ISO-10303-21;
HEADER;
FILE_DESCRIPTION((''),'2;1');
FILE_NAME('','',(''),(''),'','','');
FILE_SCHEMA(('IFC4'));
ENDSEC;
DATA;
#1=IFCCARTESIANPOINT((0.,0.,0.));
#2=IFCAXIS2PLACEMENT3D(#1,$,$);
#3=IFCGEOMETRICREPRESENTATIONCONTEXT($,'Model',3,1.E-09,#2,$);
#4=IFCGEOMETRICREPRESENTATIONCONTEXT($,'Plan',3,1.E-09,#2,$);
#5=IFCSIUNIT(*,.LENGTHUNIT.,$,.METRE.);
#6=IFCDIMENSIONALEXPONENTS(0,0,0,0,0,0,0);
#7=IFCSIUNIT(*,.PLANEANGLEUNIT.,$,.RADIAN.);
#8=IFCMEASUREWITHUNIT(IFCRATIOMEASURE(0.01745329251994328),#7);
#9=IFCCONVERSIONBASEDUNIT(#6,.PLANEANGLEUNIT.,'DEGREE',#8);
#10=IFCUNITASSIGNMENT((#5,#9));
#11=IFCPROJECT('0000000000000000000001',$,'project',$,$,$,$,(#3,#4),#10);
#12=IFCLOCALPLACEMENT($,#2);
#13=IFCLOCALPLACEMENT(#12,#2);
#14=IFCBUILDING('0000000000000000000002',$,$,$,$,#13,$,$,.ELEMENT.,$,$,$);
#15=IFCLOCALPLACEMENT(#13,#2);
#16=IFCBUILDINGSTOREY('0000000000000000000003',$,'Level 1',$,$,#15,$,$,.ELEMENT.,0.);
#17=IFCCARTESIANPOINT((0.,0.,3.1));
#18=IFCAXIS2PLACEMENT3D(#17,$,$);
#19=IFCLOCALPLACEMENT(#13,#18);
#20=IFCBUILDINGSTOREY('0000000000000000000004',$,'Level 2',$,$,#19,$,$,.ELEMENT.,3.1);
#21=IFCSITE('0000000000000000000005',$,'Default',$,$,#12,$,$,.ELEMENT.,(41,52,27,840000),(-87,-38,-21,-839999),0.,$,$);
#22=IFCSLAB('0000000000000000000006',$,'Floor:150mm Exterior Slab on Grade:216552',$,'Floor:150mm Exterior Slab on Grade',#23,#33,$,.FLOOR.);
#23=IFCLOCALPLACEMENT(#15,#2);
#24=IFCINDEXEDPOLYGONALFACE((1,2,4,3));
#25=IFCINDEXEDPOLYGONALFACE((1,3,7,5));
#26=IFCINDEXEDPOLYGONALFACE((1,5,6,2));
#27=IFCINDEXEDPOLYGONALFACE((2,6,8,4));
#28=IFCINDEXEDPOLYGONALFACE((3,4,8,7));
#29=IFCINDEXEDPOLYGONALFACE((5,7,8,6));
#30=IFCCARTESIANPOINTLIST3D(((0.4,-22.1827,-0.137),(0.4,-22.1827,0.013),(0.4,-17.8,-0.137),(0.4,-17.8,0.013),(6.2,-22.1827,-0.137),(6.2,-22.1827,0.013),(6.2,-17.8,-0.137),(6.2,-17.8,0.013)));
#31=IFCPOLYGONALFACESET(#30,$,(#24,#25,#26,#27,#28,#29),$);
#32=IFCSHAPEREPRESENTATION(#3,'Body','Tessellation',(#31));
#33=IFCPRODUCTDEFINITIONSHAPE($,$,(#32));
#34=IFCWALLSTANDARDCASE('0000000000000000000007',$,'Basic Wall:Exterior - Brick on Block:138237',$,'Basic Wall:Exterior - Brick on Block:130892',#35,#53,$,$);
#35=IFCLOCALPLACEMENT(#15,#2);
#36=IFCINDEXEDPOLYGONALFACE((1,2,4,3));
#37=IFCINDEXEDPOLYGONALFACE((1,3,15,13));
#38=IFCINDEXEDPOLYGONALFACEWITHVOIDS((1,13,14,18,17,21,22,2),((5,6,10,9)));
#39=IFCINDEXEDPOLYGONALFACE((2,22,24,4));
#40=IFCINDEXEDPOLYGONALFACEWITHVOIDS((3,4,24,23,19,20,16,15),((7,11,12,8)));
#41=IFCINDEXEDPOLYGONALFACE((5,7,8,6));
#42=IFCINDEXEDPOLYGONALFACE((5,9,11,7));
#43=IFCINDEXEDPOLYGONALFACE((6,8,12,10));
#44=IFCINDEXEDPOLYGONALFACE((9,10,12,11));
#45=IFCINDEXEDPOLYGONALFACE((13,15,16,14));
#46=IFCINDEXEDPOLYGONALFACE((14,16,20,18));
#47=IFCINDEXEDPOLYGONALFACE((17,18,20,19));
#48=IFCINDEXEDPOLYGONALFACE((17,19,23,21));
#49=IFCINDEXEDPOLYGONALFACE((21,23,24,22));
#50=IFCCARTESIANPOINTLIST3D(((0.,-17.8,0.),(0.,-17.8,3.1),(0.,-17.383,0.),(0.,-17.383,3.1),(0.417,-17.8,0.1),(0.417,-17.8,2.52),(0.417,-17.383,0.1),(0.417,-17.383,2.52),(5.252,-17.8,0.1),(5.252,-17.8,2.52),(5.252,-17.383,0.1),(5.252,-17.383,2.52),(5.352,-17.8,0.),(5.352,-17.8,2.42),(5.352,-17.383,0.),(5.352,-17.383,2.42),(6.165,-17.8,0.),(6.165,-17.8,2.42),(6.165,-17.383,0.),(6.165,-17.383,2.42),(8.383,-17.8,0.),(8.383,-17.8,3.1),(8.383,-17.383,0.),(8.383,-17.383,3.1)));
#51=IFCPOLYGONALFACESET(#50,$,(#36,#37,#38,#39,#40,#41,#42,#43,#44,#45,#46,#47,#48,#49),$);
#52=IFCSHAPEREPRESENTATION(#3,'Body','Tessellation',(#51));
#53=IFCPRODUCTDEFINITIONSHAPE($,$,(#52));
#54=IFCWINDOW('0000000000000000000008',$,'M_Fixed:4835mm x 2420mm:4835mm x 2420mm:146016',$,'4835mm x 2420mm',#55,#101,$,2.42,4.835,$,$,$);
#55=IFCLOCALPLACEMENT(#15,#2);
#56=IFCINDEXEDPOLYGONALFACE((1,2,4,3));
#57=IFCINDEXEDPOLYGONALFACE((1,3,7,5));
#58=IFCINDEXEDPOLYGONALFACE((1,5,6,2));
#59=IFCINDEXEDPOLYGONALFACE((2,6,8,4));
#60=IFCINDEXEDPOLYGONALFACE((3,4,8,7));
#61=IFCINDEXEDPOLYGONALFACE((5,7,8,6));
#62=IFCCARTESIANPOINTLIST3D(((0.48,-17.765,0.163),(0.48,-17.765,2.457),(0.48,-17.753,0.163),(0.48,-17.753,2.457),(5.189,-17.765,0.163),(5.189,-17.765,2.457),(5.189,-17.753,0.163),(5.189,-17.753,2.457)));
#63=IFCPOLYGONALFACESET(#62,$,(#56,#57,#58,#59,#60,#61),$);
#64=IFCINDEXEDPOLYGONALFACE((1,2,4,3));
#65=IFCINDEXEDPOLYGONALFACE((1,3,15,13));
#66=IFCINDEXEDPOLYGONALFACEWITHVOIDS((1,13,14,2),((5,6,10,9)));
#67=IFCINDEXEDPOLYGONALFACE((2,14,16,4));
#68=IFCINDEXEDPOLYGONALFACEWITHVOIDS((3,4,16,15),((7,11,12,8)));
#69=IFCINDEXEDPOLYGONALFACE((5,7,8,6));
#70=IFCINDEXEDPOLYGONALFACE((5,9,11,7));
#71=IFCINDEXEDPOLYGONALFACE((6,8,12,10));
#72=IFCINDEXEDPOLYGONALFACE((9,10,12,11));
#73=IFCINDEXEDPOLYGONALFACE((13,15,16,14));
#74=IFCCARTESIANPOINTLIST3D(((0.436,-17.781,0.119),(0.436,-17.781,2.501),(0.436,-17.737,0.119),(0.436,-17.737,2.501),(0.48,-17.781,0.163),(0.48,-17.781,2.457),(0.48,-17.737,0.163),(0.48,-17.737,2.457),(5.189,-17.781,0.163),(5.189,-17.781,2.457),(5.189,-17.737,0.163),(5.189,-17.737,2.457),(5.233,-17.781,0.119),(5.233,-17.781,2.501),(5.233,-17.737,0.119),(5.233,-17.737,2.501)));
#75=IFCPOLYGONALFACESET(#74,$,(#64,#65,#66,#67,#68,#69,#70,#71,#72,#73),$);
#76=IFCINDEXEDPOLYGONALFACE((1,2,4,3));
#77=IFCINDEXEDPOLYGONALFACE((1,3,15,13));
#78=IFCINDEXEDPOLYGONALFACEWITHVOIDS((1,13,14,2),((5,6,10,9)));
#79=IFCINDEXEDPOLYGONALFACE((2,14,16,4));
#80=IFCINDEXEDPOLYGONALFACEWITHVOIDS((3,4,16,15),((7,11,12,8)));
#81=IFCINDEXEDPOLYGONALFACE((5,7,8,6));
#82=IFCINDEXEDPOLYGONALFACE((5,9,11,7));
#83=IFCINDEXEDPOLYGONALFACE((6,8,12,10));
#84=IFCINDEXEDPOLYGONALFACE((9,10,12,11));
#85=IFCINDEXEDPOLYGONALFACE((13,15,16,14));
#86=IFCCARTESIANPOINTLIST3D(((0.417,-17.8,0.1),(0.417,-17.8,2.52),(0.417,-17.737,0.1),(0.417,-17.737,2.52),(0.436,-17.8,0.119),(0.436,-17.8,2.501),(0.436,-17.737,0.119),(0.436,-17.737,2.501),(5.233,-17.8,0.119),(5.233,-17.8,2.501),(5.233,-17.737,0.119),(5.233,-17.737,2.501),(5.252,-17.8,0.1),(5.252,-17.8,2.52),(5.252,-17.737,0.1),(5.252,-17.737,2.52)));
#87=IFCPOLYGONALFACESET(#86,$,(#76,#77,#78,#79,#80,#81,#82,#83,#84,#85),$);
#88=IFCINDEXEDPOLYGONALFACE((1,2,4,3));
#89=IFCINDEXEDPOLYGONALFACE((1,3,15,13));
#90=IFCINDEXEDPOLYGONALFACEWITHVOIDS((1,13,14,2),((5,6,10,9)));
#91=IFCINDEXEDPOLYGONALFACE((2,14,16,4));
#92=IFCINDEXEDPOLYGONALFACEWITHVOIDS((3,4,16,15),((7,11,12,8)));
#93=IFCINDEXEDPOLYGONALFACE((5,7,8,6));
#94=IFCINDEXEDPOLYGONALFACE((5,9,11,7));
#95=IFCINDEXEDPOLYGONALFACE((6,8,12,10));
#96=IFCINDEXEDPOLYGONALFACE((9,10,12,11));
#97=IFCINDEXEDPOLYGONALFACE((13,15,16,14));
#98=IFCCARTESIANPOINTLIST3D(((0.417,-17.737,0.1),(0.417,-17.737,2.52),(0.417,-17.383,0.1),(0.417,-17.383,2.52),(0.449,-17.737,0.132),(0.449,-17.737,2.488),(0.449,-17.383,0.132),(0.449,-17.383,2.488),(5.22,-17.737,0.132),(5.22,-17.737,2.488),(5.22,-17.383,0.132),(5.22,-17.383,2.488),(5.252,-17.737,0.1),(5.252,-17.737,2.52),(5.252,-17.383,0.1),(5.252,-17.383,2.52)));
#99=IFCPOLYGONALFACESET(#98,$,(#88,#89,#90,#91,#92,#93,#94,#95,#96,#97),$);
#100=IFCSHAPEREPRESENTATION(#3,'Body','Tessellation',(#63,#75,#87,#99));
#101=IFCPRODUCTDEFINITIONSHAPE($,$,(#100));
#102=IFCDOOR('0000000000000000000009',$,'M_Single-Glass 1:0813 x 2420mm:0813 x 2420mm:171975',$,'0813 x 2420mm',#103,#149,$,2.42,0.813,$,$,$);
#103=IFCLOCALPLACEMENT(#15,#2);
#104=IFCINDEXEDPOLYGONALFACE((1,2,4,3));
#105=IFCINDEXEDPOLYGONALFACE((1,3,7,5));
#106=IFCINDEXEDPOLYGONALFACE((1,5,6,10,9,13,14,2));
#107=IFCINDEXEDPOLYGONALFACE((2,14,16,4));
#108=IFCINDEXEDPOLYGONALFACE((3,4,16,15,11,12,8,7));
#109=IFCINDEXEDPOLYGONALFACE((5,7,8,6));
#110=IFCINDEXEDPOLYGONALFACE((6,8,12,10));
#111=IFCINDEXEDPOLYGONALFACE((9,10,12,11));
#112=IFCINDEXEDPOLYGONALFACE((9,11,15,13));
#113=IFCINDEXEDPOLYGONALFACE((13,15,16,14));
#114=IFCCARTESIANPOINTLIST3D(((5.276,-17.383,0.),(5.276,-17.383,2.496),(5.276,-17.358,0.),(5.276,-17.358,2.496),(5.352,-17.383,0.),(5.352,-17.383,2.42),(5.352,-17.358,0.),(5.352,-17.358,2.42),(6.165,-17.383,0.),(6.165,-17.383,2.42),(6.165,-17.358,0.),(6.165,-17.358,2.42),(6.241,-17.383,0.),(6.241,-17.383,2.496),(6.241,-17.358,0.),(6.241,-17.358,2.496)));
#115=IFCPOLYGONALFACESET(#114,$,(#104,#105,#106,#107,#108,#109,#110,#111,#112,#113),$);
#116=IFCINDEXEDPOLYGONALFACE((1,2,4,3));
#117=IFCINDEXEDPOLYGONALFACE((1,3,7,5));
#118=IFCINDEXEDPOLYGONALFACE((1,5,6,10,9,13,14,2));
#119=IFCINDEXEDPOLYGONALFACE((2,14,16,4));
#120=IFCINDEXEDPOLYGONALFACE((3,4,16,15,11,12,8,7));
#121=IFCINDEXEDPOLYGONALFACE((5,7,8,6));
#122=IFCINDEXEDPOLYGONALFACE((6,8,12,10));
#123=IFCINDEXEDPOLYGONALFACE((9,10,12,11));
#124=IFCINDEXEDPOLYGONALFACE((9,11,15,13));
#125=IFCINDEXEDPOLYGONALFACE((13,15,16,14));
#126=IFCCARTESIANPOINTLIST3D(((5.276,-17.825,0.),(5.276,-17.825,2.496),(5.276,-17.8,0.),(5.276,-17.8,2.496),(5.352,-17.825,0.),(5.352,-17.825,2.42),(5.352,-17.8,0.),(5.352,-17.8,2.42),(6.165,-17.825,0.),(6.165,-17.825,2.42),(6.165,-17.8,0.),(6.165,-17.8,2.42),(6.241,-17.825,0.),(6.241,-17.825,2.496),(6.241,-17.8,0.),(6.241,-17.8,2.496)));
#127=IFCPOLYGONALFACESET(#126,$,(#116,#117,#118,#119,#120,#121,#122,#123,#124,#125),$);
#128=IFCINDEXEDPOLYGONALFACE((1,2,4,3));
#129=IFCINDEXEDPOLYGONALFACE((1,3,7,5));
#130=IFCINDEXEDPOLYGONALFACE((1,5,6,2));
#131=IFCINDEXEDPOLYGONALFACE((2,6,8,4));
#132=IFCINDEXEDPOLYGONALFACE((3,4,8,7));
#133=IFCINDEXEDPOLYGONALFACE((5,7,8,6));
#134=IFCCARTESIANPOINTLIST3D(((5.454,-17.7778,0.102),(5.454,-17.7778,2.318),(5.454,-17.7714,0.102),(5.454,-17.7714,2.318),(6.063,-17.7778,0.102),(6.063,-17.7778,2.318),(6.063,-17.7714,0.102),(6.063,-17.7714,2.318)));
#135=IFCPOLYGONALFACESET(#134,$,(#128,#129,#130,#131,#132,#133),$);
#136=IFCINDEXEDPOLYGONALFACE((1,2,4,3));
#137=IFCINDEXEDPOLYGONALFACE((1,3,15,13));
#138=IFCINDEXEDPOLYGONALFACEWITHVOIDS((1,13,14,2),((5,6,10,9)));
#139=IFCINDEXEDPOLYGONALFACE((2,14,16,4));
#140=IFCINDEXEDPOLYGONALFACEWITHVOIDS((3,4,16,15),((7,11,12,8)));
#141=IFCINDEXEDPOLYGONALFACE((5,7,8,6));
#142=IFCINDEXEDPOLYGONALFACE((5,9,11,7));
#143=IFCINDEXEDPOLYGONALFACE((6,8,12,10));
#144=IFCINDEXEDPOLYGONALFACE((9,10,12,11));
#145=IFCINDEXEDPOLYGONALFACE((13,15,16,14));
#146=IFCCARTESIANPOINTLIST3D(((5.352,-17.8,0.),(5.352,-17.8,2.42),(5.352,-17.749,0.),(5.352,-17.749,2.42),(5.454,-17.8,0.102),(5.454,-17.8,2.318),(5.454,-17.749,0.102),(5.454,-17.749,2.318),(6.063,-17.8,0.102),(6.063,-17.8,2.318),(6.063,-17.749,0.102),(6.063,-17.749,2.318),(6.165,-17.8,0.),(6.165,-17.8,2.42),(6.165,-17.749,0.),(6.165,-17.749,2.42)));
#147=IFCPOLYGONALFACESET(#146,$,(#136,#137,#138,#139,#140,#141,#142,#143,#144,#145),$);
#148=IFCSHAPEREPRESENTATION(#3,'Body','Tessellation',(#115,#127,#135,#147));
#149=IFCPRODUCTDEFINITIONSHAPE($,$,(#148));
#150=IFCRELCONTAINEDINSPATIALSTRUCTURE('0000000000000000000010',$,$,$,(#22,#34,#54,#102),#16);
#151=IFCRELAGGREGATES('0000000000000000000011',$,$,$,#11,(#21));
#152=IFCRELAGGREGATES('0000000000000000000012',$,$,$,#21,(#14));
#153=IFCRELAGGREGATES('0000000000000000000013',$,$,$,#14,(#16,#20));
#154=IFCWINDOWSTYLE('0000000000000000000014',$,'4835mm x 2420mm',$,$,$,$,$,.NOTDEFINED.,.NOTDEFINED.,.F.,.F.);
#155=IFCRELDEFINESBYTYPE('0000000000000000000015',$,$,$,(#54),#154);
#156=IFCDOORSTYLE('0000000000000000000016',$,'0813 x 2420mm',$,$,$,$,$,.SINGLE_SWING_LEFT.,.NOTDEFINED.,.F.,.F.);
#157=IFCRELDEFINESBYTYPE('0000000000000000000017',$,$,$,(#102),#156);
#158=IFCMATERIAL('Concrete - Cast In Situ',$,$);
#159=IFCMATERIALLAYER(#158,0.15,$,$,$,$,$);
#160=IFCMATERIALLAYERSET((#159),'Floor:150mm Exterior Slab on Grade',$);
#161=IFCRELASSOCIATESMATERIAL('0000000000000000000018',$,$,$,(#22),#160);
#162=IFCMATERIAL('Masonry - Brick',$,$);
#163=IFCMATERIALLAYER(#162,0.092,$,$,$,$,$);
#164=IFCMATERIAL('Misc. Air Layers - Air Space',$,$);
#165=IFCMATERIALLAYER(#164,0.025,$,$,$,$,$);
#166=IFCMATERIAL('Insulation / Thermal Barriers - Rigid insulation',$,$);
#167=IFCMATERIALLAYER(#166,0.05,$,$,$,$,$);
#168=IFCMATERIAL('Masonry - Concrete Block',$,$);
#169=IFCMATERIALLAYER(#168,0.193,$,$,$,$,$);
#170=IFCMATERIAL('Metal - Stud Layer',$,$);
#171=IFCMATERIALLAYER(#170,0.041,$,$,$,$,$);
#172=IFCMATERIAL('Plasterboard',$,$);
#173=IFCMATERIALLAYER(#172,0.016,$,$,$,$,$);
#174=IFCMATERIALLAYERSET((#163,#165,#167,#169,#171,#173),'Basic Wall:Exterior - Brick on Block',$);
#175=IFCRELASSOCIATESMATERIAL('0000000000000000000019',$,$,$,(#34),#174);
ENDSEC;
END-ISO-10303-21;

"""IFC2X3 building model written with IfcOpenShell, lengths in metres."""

from ifc_helpers import new_model, entity, si_unit, converted_unit, frame, frame_2d, origin, origin_2d_with_axis, place, context, project, spatial, polyline, rectangle, outline, extrude, source, transform, mapped, material, layer, layer_set, layer_usage, type_object, type_shapes, element, fill, save


model = new_model("IFC2X3")

# Units and contexts
model_context = context("Model", 3, precision=1e-09, world=origin())
plan_context = context("Plan", 3, precision=1e-09, world=origin())
ifc_project = project(units=[si_unit("LENGTHUNIT", "METRE"), converted_unit("PLANEANGLEUNIT", "DEGREE", entity("IfcRatioMeasure", 0.01745329251994328), si_unit("PLANEANGLEUNIT", "RADIAN"), dimensions=[0, 0, 0, 0, 0, 0, 0])], contexts=[model_context, plan_context])

# Site, building, storey
site_placement = place(None, origin())
site = spatial("IfcSite", under=ifc_project, at=site_placement, Name="Default", CompositionType="ELEMENT", RefLatitude=(41, 52, 27, 840000), RefLongitude=(-87, -38, -21, -839999), RefElevation=0.0)
building_placement = place(site_placement, origin())
building = spatial("IfcBuilding", under=site, at=building_placement, CompositionType="ELEMENT")
storey_1_placement = place(building_placement, origin())
storey_1 = spatial("IfcBuildingStorey", under=building, at=storey_1_placement, Name="Level 1", CompositionType="ELEMENT", Elevation=0.0)

# Slab
ifc_material_1 = material(Name="Concrete - Cast In Situ")
ifc_layer_1 = layer(ifc_material_1, 0.15)
ifc_layer_set_1 = layer_set([ifc_layer_1], Name="Floor:150mm Exterior Slab on Grade")
ifc_layer_usage_1 = layer_usage(ifc_layer_set_1, "AXIS3", "POSITIVE", 0.0)
slab_1_placement = place(storey_1_placement, frame((0.4, -22.1827, -0.137)))
element("IfcSlab", 1, at=slab_1_placement, inside=storey_1, material=ifc_layer_usage_1, Name="Floor:150mm Exterior Slab on Grade:216552", ObjectType="Floor:150mm Exterior Slab on Grade", PredefinedType="FLOOR", context=model_context, shape_type="SweptSolid", body=[
    extrude(rectangle(XDim=5.8, YDim=4.3827, at=origin_2d_with_axis()), frame((2.9, 2.1914, 0.15), z_axis=(0.0, 0.0, -1.0), x_axis=(-1.0, 0.0, 0.0)), (0.0, 0.0, 1.0), 0.15),
])

# Wall, openings, window, door
ifc_material_2 = material(Name="Masonry - Brick")
ifc_layer_2 = layer(ifc_material_2, 0.092)
ifc_material_3 = material(Name="Misc. Air Layers - Air Space")
ifc_layer_3 = layer(ifc_material_3, 0.025)
ifc_material_4 = material(Name="Insulation / Thermal Barriers - Rigid insulation")
ifc_layer_4 = layer(ifc_material_4, 0.05)
ifc_material_5 = material(Name="Masonry - Concrete Block")
ifc_layer_5 = layer(ifc_material_5, 0.193)
ifc_material_6 = material(Name="Metal - Stud Layer")
ifc_layer_6 = layer(ifc_material_6, 0.041)
ifc_material_7 = material(Name="Plasterboard")
ifc_layer_7 = layer(ifc_material_7, 0.016)
ifc_layer_set_2 = layer_set([ifc_layer_2, ifc_layer_3, ifc_layer_4, ifc_layer_5, ifc_layer_6, ifc_layer_7], Name="Basic Wall:Exterior - Brick on Block")
ifc_layer_usage_2 = layer_usage(ifc_layer_set_2, "AXIS2", "NEGATIVE", 0.2085)
wall_1_placement = place(storey_1_placement, frame((8.383, -17.5915, 0.0), z_axis=(0.0, 0.0, 1.0), x_axis=(-1.0, 0.0, 0.0)))
wall_1 = element("IfcWallStandardCase", 2, at=wall_1_placement, inside=storey_1, material=ifc_layer_usage_2, Name="Basic Wall:Exterior - Brick on Block:138237", ObjectType="Basic Wall:Exterior - Brick on Block:130892", context=model_context, shape_type="SweptSolid", body=[
    extrude(rectangle(XDim=8.383, YDim=0.417, at=frame_2d((4.1915, 0.0), x_axis=(-1.0, 0.0))), origin(), (0.0, 0.0, 1.0), 3.1),
])
opening_1_placement = place(wall_1_placement, frame((3.131, -0.2085, 0.1)))
opening_1 = element("IfcOpeningElement", 3, at=opening_1_placement, cuts=wall_1, ObjectType="Opening", context=model_context, shape_type="SweptSolid", body=[
    extrude(rectangle(XDim=2.42, YDim=4.835, at=frame_2d((1.21, 2.4175), x_axis=(1.0, 0.0))), frame((0.0, 0.0, 0.0), z_axis=(0.0, 1.0, 0.0), x_axis=(0.0, 0.0, 1.0)), (0.0, 0.0, 1.0), 0.417),
])
opening_2_placement = place(wall_1_placement, frame((2.218, -0.2085, 0.0)))
opening_2 = element("IfcOpeningElement", 4, at=opening_2_placement, cuts=wall_1, ObjectType="Opening", context=model_context, shape_type="SweptSolid", body=[
    extrude(rectangle(XDim=0.813, YDim=2.42, at=frame_2d((1.21, 0.4065), x_axis=(0.0, -1.0))), frame((0.0, 0.0, 0.0), z_axis=(0.0, 1.0, 0.0), x_axis=(0.0, 0.0, 1.0)), (0.0, 0.0, 1.0), 0.417),
])
window_style_1 = type_object("IfcWindowStyle", Name="4835mm x 2420mm", ConstructionType="NOTDEFINED", OperationType="NOTDEFINED", ParameterTakesPrecedence=False, Sizeable=False)
shared_shape_1 = source(origin(), model_context, "Body", "SweptSolid", [
    extrude(rectangle(XDim=0.012, YDim=4.709, at=origin_2d_with_axis()), frame((2.4175, 0.376, 0.063), z_axis=(0.0, 0.0, 1.0), x_axis=(0.0, -1.0, 0.0)), (0.0, 0.0, 1.0), 2.294),
    extrude(outline(polyline([(-2.3985, -1.191), (2.3985, -1.191), (2.3985, 1.191), (-2.3985, 1.191), (-2.3985, -1.191)]), holes=[polyline([(-2.3545, -1.147), (-2.3545, 1.147), (2.3545, 1.147), (2.3545, -1.147), (-2.3545, -1.147)])]), frame((2.4175, 0.354, 1.21), z_axis=(0.0, 1.0, 0.0), x_axis=(1.0, 0.0, 0.0)), (0.0, 0.0, 1.0), 0.044),
    extrude(outline(polyline([(-2.4175, -1.21), (2.4175, -1.21), (2.4175, 1.21), (-2.4175, 1.21), (-2.4175, -1.21)]), holes=[polyline([(-2.3985, -1.191), (-2.3985, 1.191), (2.3985, 1.191), (2.3985, -1.191), (-2.3985, -1.191)])]), frame((2.4175, 0.354, 1.21), z_axis=(0.0, 1.0, 0.0), x_axis=(1.0, 0.0, 0.0)), (0.0, 0.0, 1.0), 0.063),
    extrude(outline(polyline([(-2.4175, -1.21), (2.4175, -1.21), (2.4175, 1.21), (-2.4175, 1.21), (-2.4175, -1.21)]), holes=[polyline([(-2.3855, -1.178), (-2.3855, 1.178), (2.3855, 1.178), (2.3855, -1.178), (-2.3855, -1.178)])]), frame((2.4175, 0.0, 1.21), z_axis=(0.0, 1.0, 0.0), x_axis=(1.0, 0.0, 0.0)), (0.0, 0.0, 1.0), 0.354),
])
type_shapes(window_style_1, [shared_shape_1])
window_1_placement = place(opening_1_placement, origin())
window_1 = element("IfcWindow", 5, at=window_1_placement, inside=storey_1, type_object=window_style_1, Name="M_Fixed:4835mm x 2420mm:4835mm x 2420mm:146016", ObjectType="4835mm x 2420mm", OverallHeight=2.42, OverallWidth=4.835, context=model_context, shape_type="MappedRepresentation", body=[
    mapped(shared_shape_1, transform((0.0, 0.0, 0.0), scale=1.0)),
])
fill(opening_1, window_1)
door_style_1 = type_object("IfcDoorStyle", Name="0813 x 2420mm", ConstructionType="NOTDEFINED", OperationType="SINGLE_SWING_LEFT", ParameterTakesPrecedence=False, Sizeable=False)
shared_shape_2 = source(origin(), model_context, "Body", "SweptSolid", [
    extrude(outline(polyline([(-0.4065, -1.191), (-0.4065, 1.229), (-0.4825, 1.229), (-0.4825, -1.267), (0.4825, -1.267), (0.4825, 1.229), (0.4065, 1.229), (0.4065, -1.191), (-0.4065, -1.191)])), frame((0.4065, 0.0, 1.229), z_axis=(0.0, 1.0, 0.0), x_axis=(1.0, 0.0, 0.0)), (0.0, 0.0, -1.0), 0.025),
    extrude(outline(polyline([(-0.4065, -1.191), (-0.4065, 1.229), (-0.4825, 1.229), (-0.4825, -1.267), (0.4825, -1.267), (0.4825, 1.229), (0.4065, 1.229), (0.4065, -1.191), (-0.4065, -1.191)])), frame((0.4065, 0.442, 1.229), z_axis=(0.0, 1.0, 0.0), x_axis=(1.0, 0.0, 0.0)), (0.0, 0.0, -1.0), 0.025),
    extrude(rectangle(XDim=0.609, YDim=0.0064, at=origin_2d_with_axis()), frame((0.4065, 0.3916, 0.102)), (0.0, 0.0, 1.0), 2.216),
    extrude(outline(polyline([(-1.21, -0.4065), (1.21, -0.4065), (1.21, 0.4065), (-1.21, 0.4065), (-1.21, -0.4065)]), holes=[polyline([(-1.108, 0.3045), (1.108, 0.3045), (1.108, -0.3045), (-1.108, -0.3045), (-1.108, 0.3045)])]), frame((0.4065, 0.417, 1.21), z_axis=(0.0, -1.0, 0.0), x_axis=(0.0, 0.0, -1.0)), (0.0, 0.0, 1.0), 0.051),
])
type_shapes(door_style_1, [shared_shape_2])
door_1_placement = place(opening_2_placement, origin())
door_1 = element("IfcDoor", 6, at=door_1_placement, inside=storey_1, type_object=door_style_1, Name="M_Single-Glass 1:0813 x 2420mm:0813 x 2420mm:171975", ObjectType="0813 x 2420mm", OverallHeight=2.42, OverallWidth=0.813, context=model_context, shape_type="MappedRepresentation", body=[
    mapped(shared_shape_2, transform((0.0, 0.0, 0.0), scale=1.0)),
])
fill(opening_2, door_1)

# Shared definitions
storey_2_placement = place(building_placement, frame((0.0, 0.0, 3.1)))
storey_2 = spatial("IfcBuildingStorey", under=building, at=storey_2_placement, Name="Level 2", CompositionType="ELEMENT", Elevation=3.1)

save(model, "model.ifc")
